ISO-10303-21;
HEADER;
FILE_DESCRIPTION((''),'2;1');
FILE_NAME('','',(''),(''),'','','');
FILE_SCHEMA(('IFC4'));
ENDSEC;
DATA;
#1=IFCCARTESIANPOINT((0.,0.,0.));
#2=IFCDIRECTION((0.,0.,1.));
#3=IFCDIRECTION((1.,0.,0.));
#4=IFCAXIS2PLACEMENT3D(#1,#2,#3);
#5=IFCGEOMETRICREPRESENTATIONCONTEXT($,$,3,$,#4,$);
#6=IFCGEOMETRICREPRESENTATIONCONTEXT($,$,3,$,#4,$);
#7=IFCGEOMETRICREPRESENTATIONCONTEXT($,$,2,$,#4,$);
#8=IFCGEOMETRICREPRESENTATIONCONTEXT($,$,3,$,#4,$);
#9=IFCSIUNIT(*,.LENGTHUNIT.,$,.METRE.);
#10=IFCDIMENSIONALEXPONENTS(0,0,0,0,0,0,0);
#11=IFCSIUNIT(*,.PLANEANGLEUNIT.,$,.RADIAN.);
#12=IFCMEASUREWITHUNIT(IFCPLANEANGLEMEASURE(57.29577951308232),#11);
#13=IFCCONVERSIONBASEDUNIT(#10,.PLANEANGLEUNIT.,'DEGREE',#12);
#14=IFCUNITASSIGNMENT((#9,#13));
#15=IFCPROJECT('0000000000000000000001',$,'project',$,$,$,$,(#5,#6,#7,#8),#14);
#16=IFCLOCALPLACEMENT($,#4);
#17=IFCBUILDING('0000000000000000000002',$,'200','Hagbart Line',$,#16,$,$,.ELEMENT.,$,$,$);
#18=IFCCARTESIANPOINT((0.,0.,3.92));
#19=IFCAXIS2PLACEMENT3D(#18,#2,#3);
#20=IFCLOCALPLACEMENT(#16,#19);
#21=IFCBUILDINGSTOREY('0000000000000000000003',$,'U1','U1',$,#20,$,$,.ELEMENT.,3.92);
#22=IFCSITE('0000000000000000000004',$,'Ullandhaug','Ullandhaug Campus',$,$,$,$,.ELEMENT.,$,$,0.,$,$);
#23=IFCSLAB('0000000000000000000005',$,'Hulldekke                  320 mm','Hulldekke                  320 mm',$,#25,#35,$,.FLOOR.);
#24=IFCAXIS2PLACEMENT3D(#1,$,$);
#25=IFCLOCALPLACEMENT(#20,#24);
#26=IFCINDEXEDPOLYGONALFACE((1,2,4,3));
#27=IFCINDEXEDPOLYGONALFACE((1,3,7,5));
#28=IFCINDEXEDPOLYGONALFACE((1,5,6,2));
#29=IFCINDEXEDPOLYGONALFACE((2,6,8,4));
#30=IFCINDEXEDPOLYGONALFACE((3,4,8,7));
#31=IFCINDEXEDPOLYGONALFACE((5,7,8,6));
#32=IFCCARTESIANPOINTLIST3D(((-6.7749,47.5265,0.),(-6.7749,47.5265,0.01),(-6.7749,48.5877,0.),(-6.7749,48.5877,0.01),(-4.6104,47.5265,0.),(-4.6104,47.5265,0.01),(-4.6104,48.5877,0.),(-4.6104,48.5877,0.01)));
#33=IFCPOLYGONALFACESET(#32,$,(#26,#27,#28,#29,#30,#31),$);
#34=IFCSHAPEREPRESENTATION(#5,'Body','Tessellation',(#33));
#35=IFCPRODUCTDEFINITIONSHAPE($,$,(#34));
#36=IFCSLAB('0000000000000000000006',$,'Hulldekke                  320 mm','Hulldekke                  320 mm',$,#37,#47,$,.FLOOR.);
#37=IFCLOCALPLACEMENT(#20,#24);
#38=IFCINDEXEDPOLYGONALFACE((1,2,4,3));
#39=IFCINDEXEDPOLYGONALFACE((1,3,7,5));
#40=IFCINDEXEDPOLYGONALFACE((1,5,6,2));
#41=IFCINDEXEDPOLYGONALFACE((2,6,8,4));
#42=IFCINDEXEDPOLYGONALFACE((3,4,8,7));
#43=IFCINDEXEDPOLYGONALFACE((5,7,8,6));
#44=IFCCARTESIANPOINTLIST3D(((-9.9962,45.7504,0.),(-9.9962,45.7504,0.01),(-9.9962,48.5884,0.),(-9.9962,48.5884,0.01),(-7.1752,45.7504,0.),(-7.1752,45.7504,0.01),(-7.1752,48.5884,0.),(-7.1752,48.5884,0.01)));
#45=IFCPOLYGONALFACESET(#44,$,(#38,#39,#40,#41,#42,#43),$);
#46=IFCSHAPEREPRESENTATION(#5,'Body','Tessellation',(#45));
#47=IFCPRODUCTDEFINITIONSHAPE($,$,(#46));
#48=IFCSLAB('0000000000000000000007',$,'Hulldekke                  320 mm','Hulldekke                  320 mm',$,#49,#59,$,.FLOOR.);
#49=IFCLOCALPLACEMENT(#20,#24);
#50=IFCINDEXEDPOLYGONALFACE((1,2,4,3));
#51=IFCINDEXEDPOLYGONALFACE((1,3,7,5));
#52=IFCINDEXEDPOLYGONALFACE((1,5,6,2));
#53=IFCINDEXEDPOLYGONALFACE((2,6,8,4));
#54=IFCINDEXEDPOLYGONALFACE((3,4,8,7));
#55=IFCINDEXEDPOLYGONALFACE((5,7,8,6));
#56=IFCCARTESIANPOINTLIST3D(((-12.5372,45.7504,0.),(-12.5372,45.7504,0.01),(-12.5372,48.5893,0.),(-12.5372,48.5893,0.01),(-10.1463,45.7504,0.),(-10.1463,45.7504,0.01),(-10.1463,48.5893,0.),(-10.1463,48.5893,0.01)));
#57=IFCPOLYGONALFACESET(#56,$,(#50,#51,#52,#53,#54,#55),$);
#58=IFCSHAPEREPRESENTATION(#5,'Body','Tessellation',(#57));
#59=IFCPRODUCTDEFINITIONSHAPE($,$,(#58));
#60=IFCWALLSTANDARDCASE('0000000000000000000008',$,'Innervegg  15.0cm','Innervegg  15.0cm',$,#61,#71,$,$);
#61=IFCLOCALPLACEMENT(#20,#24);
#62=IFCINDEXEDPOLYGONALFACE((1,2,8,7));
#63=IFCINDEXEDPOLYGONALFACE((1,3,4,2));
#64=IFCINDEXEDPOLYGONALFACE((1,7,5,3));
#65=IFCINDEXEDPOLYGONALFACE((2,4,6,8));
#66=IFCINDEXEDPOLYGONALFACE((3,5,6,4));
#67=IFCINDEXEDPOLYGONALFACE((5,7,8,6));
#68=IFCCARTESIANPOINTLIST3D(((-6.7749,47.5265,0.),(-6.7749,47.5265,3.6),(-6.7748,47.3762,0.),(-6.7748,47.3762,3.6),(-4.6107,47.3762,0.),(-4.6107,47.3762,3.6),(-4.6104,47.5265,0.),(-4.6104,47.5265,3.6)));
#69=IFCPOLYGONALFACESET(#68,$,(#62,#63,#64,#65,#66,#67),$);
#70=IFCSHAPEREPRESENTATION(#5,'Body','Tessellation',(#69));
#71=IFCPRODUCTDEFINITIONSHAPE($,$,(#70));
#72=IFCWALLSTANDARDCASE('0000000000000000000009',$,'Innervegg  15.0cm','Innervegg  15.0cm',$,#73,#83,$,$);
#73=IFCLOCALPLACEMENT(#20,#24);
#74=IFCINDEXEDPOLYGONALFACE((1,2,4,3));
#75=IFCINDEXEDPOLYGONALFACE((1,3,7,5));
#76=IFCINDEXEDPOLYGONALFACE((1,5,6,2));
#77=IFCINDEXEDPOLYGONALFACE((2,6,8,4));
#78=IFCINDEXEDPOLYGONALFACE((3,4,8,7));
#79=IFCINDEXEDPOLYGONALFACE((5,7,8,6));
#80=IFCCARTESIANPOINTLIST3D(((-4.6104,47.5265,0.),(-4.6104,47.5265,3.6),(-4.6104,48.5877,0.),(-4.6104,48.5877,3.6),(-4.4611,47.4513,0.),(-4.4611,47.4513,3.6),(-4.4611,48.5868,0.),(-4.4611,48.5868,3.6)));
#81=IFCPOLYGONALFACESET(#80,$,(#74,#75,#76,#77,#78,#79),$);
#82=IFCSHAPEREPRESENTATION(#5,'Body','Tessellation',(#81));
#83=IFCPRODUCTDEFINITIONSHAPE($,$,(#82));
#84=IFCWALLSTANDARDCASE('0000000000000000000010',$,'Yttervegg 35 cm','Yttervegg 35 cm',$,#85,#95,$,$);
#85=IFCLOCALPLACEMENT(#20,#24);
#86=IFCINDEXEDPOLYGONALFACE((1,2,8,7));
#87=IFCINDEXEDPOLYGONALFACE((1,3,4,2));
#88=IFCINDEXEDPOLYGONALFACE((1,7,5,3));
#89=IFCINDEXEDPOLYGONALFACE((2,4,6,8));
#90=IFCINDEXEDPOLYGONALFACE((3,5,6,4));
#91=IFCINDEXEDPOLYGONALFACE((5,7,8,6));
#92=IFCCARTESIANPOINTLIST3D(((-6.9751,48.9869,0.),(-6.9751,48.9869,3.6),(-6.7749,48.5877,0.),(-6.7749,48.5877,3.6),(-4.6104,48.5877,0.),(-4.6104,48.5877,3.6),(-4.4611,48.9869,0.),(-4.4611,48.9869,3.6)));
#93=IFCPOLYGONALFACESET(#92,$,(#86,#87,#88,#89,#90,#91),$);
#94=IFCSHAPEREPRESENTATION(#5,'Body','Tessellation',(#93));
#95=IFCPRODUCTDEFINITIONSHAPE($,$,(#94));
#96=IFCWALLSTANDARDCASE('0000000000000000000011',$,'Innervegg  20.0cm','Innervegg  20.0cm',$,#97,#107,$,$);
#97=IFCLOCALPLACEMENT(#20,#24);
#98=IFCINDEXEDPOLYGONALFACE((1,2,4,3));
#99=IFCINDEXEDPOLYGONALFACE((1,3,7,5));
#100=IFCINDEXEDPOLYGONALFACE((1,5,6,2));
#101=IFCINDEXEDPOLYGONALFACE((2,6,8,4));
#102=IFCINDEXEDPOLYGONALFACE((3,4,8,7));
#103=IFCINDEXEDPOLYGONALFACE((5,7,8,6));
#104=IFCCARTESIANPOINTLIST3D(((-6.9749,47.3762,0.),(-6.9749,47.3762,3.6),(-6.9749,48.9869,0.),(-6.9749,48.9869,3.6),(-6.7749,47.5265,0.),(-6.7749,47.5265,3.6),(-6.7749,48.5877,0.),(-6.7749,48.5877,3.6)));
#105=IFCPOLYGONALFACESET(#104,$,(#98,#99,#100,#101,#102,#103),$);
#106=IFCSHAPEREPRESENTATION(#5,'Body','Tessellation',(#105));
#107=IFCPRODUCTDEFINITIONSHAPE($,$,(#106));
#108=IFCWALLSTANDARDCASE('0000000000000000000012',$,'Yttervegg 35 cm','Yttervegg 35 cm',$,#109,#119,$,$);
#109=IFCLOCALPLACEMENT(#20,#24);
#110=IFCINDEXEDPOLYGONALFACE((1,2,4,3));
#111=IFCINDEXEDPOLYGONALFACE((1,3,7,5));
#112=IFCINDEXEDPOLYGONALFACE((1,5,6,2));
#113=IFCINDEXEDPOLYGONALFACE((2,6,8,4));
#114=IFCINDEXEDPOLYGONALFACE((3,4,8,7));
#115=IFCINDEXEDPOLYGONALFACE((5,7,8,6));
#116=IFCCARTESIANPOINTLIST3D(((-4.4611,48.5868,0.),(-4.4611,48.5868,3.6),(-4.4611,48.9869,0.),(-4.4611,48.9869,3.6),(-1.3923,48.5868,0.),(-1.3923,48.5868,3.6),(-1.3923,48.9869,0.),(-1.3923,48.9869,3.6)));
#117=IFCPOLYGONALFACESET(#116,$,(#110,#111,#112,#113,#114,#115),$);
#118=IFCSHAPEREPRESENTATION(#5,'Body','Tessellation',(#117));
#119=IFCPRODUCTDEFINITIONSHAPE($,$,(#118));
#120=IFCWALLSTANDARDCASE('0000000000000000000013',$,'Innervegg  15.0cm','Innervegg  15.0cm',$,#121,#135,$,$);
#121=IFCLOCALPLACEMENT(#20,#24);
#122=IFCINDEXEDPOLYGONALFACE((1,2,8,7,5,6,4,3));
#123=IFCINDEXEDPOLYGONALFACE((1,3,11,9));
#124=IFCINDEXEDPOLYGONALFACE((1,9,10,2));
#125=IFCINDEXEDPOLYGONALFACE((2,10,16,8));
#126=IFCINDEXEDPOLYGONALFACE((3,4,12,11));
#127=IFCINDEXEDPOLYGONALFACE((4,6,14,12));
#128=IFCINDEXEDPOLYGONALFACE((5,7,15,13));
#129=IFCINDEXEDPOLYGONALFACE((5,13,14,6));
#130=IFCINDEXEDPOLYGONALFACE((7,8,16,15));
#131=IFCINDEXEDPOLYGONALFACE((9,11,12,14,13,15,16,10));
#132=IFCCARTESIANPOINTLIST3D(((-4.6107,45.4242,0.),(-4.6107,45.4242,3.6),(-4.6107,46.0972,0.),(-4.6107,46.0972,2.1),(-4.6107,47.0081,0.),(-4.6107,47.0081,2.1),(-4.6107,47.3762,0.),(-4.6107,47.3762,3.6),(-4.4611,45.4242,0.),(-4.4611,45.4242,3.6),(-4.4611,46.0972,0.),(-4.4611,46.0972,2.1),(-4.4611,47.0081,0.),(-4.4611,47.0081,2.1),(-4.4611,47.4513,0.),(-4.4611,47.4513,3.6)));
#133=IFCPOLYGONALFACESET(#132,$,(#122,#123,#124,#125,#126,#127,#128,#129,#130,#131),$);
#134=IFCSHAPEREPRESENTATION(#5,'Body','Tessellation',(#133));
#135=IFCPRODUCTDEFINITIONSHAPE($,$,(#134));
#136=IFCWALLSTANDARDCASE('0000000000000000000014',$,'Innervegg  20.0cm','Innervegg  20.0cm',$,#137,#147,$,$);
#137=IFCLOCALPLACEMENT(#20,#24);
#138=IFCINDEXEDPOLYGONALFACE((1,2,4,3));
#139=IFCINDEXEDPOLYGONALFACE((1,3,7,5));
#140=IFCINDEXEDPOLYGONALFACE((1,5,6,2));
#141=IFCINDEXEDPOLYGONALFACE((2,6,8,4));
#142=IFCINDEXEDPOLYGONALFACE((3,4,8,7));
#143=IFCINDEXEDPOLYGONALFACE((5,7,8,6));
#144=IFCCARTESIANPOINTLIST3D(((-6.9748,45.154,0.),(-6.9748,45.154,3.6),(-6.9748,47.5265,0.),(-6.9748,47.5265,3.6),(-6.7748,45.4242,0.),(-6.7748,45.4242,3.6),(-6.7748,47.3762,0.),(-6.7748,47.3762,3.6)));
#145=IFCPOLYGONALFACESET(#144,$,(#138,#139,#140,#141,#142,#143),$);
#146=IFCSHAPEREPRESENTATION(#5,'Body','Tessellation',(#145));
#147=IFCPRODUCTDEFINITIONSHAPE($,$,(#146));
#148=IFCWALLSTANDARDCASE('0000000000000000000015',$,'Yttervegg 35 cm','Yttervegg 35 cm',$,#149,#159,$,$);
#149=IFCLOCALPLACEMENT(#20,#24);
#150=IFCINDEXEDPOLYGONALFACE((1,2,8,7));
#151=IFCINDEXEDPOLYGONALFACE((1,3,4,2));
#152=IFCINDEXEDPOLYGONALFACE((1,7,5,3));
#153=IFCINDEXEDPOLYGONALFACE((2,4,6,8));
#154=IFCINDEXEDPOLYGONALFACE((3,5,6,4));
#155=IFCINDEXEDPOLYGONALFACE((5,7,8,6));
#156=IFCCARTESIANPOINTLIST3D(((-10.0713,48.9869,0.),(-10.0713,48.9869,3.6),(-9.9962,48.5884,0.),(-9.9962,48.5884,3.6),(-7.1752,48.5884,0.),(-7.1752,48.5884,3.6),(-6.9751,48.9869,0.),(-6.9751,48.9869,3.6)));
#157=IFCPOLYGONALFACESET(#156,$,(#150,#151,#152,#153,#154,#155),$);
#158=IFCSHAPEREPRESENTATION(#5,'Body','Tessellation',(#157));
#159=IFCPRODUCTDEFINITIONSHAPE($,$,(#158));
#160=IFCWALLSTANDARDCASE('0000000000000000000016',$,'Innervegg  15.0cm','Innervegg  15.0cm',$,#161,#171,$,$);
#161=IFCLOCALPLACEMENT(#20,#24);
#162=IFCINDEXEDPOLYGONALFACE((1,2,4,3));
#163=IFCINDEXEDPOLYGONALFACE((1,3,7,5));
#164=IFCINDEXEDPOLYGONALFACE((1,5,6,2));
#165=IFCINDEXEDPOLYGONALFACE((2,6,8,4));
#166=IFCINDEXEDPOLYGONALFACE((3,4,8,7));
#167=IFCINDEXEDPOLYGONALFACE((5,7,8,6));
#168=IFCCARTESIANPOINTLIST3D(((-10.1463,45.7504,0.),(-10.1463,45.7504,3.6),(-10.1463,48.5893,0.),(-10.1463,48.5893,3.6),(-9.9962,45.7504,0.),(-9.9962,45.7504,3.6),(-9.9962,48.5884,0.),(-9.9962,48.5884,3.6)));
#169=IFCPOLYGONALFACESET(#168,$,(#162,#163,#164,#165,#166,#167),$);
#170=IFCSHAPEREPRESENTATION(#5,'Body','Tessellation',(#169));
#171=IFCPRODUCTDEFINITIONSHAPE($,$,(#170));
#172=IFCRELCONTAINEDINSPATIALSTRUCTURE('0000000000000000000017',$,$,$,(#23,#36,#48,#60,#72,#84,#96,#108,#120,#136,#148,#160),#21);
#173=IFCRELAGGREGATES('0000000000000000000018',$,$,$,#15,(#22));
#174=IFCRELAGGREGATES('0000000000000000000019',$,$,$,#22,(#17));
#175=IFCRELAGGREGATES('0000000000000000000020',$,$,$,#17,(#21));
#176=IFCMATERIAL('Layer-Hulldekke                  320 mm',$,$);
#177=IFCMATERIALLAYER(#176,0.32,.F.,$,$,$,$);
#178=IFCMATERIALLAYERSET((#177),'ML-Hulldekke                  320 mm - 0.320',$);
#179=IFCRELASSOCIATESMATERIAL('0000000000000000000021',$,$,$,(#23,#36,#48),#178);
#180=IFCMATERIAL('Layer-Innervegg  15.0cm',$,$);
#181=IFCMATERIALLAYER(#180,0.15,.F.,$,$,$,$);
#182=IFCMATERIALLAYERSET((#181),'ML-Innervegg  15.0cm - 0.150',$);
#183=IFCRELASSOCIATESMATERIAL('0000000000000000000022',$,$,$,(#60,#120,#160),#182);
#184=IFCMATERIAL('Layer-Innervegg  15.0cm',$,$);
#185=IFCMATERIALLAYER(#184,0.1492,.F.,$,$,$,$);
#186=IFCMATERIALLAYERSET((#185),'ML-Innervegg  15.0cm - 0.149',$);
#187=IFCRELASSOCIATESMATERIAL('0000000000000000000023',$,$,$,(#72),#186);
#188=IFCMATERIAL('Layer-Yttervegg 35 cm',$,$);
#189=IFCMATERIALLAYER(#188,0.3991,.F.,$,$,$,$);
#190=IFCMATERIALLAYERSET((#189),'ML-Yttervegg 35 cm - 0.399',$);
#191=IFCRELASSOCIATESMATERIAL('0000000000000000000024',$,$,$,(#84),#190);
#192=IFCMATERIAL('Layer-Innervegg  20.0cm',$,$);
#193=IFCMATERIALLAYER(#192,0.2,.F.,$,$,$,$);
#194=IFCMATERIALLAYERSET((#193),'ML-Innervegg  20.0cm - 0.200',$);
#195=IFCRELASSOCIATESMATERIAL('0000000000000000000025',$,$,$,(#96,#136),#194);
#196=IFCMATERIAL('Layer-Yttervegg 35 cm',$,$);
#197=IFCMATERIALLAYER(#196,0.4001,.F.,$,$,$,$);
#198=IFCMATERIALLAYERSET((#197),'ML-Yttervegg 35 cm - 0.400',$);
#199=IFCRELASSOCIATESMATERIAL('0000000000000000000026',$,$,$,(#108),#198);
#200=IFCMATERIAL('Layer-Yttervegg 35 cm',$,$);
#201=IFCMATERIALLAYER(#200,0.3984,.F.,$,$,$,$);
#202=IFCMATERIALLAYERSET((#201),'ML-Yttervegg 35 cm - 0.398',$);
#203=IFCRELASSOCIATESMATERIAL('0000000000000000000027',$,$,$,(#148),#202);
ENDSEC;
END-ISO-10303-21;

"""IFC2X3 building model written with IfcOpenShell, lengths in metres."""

from ifc_helpers import new_model, entity, si_unit, converted_unit, frame, origin_with_axes, place, context, project, spatial, polyline, outline, extrude, material, layer, layer_set, layer_usage, element, save


model = new_model("IFC2X3")

# Units and contexts
context_of_model_1 = context(None, 3, world=origin_with_axes())
context_of_model_2 = context(None, 3, world=origin_with_axes())
context_of_model_3 = context(None, 2, world=origin_with_axes())
context_of_model_4 = context(None, 3, world=origin_with_axes())
ifc_project = project(units=[si_unit("LENGTHUNIT", "METRE"), converted_unit("PLANEANGLEUNIT", "DEGREE", entity("IfcPlaneAngleMeasure", 57.29577951308232), si_unit("PLANEANGLEUNIT", "RADIAN"), dimensions=[0, 0, 0, 0, 0, 0, 0])], contexts=[context_of_model_1, context_of_model_2, context_of_model_3, context_of_model_4])

# Site, building, storey
site = spatial("IfcSite", under=ifc_project, Name="Ullandhaug", Description="Ullandhaug Campus", CompositionType="ELEMENT", RefElevation=0.0)
building_placement = place(None, origin_with_axes())
building = spatial("IfcBuilding", under=site, at=building_placement, Name="200", Description="Hagbart Line", CompositionType="ELEMENT")
storey_placement = place(building_placement, frame((0.0, 0.0, 3.92), z_axis=(0.0, 0.0, 1.0), x_axis=(1.0, 0.0, 0.0)))
storey = spatial("IfcBuildingStorey", under=building, at=storey_placement, Name="U1", Description="U1", CompositionType="ELEMENT", Elevation=3.92)

# Slabs
ifc_material_1 = material(Name="Layer-Hulldekke                  320 mm")
ifc_layer_1 = layer(ifc_material_1, 0.32, ventilated=False)
ifc_layer_set_1 = layer_set([ifc_layer_1], Name="ML-Hulldekke                  320 mm - 0.320")
ifc_layer_usage_1 = layer_usage(ifc_layer_set_1, "AXIS2", "POSITIVE", 0.0)
slab_1_placement = place(storey_placement, frame((-6.7749, 47.5265, 0.0), z_axis=(0.0, 0.0, 1.0), x_axis=(1.0, 0.0, 0.0)))
element("IfcSlab", 1, at=slab_1_placement, inside=storey, material=ifc_layer_usage_1, Name="Hulldekke                  320 mm", Description="Hulldekke                  320 mm", PredefinedType="FLOOR", context=context_of_model_1, shape_type="SweptSolid", body=[
    extrude(outline(polyline([(0.0, 0.0), (2.1645, 0.0), (2.1645, 1.0613), (0.0, 1.0613), (0.0, 0.0)])), origin_with_axes(), (0.0, 0.0, 1.0), 0.01),
])
slab_2_placement = place(storey_placement, frame((-9.9962, 45.7504, 0.0), z_axis=(0.0, 0.0, 1.0), x_axis=(1.0, 0.0, 0.0)))
element("IfcSlab", 2, at=slab_2_placement, inside=storey, material=ifc_layer_usage_1, Name="Hulldekke                  320 mm", Description="Hulldekke                  320 mm", PredefinedType="FLOOR", context=context_of_model_1, shape_type="SweptSolid", body=[
    extrude(outline(polyline([(0.0, 0.0), (2.821, 0.0), (2.821, 2.838), (0.0, 2.838), (0.0, 0.0)])), origin_with_axes(), (0.0, 0.0, 1.0), 0.01),
])
slab_3_placement = place(storey_placement, frame((-12.5372, 45.7504, 0.0), z_axis=(0.0, 0.0, 1.0), x_axis=(1.0, 0.0, 0.0)))
element("IfcSlab", 3, at=slab_3_placement, inside=storey, material=ifc_layer_usage_1, Name="Hulldekke                  320 mm", Description="Hulldekke                  320 mm", PredefinedType="FLOOR", context=context_of_model_1, shape_type="SweptSolid", body=[
    extrude(outline(polyline([(0.0, 0.0), (2.3909, 0.0), (2.3909, 2.8388), (0.0, 2.8388), (0.0, 0.0)])), origin_with_axes(), (0.0, 0.0, 1.0), 0.01),
])

# Walls
ifc_material_2 = material(Name="Layer-Innervegg  15.0cm")
ifc_layer_2 = layer(ifc_material_2, 0.15, ventilated=False)
ifc_layer_set_2 = layer_set([ifc_layer_2], Name="ML-Innervegg  15.0cm - 0.150")
ifc_layer_usage_2 = layer_usage(ifc_layer_set_2, "AXIS2", "POSITIVE", 0.0)
wall_1_placement = place(storey_placement, frame((-6.7748, 47.3762, 0.0), z_axis=(0.0, 0.0, 1.0), x_axis=(1.0, 0.0, 0.0)))
element("IfcWallStandardCase", 4, at=wall_1_placement, inside=storey, material=ifc_layer_usage_2, Name="Innervegg  15.0cm", Description="Innervegg  15.0cm", context=context_of_model_1, shape_type="SweptSolid", body=[
    extrude(outline(polyline([(0.0, 0.0), (2.1641, 0.0), (2.1644, 0.1503), (-0.0001, 0.1503), (0.0, 0.0)])), origin_with_axes(), (0.0, 0.0, 1.0), 3.6),
])
ifc_material_3 = material(Name="Layer-Innervegg  15.0cm")
ifc_layer_3 = layer(ifc_material_3, 0.1492, ventilated=False)
ifc_layer_set_3 = layer_set([ifc_layer_3], Name="ML-Innervegg  15.0cm - 0.149")
ifc_layer_usage_3 = layer_usage(ifc_layer_set_3, "AXIS2", "POSITIVE", 0.0)
wall_2_placement = place(storey_placement, frame((-4.4611, 47.4513, 0.0), z_axis=(0.0, 0.0, 1.0), x_axis=(0.0, 1.0, 0.0)))
element("IfcWallStandardCase", 5, at=wall_2_placement, inside=storey, material=ifc_layer_usage_3, Name="Innervegg  15.0cm", Description="Innervegg  15.0cm", context=context_of_model_1, shape_type="SweptSolid", body=[
    extrude(outline(polyline([(0.0, 0.0), (1.1355, 0.0), (1.1364, 0.1492), (0.0751, 0.1492), (0.0, 0.0)])), frame((0.0, 0.0, 0.0), z_axis=(0.0, 0.0, 1.0), x_axis=(1.0, 0.0, 0.0)), (0.0, 0.0, 1.0), 3.6),
])
ifc_material_4 = material(Name="Layer-Yttervegg 35 cm")
ifc_layer_4 = layer(ifc_material_4, 0.3991, ventilated=False)
ifc_layer_set_4 = layer_set([ifc_layer_4], Name="ML-Yttervegg 35 cm - 0.399")
ifc_layer_usage_4 = layer_usage(ifc_layer_set_4, "AXIS2", "POSITIVE", 0.0)
wall_3_placement = place(storey_placement, frame((-4.4611, 48.9869, 0.0), z_axis=(0.0, 0.0, 1.0), x_axis=(-1.0, 0.0, 0.0)))
element("IfcWallStandardCase", 6, at=wall_3_placement, inside=storey, material=ifc_layer_usage_4, Name="Yttervegg 35 cm", Description="Yttervegg 35 cm", context=context_of_model_1, shape_type="SweptSolid", body=[
    extrude(outline(polyline([(0.0, 0.0), (2.5139, 0.0), (2.3138, 0.3991), (0.1492, 0.3991), (0.0, 0.0)])), frame((0.0, 0.0, 0.0), z_axis=(0.0, 0.0, 1.0), x_axis=(1.0, 0.0, 0.0)), (0.0, 0.0, 1.0), 3.6),
])
ifc_material_5 = material(Name="Layer-Innervegg  20.0cm")
ifc_layer_5 = layer(ifc_material_5, 0.2, ventilated=False)
ifc_layer_set_5 = layer_set([ifc_layer_5], Name="ML-Innervegg  20.0cm - 0.200")
ifc_layer_usage_5 = layer_usage(ifc_layer_set_5, "AXIS2", "POSITIVE", 0.0)
wall_4_placement = place(storey_placement, frame((-6.9749, 48.9869, 0.0), z_axis=(0.0, 0.0, 1.0), x_axis=(0.0, -1.0, 0.0)))
element("IfcWallStandardCase", 7, at=wall_4_placement, inside=storey, material=ifc_layer_usage_5, Name="Innervegg  20.0cm", Description="Innervegg  20.0cm", context=context_of_model_1, shape_type="SweptSolid", body=[
    extrude(outline(polyline([(0.0, 0.0), (1.6107, 0.0), (1.4604, 0.2), (0.3991, 0.2), (0.0, 0.0)])), frame((0.0, 0.0, 0.0), z_axis=(0.0, 0.0, 1.0), x_axis=(1.0, 0.0, 0.0)), (0.0, 0.0, 1.0), 3.6),
])
ifc_material_6 = material(Name="Layer-Yttervegg 35 cm")
ifc_layer_6 = layer(ifc_material_6, 0.4001, ventilated=False)
ifc_layer_set_6 = layer_set([ifc_layer_6], Name="ML-Yttervegg 35 cm - 0.400")
ifc_layer_usage_6 = layer_usage(ifc_layer_set_6, "AXIS2", "POSITIVE", 0.0)
wall_5_placement = place(storey_placement, frame((-1.3923, 48.9869, 0.0), z_axis=(0.0, 0.0, 1.0), x_axis=(-1.0, 0.000001, 0.0)))
element("IfcWallStandardCase", 8, at=wall_5_placement, inside=storey, material=ifc_layer_usage_6, Name="Yttervegg 35 cm", Description="Yttervegg 35 cm", context=context_of_model_1, shape_type="SweptSolid", body=[
    extrude(outline(polyline([(0.0, 0.0), (3.0688, 0.0), (3.0688, 0.4001), (0.0, 0.4001), (0.0, 0.0)])), frame((0.0, 0.0, 0.0), z_axis=(0.0, 0.0, 1.0), x_axis=(1.0, 0.0, 0.0)), (0.0, 0.0, 1.0), 3.6),
])

# Wall, opening
wall_6_placement = place(storey_placement, frame((-4.6107, 47.3762, 0.0), z_axis=(0.0, 0.0, 1.0), x_axis=(0.0, -1.0, 0.0)))
wall_6 = element("IfcWallStandardCase", 9, at=wall_6_placement, inside=storey, material=ifc_layer_usage_2, Name="Innervegg  15.0cm", Description="Innervegg  15.0cm", context=context_of_model_1, shape_type="SweptSolid", body=[
    extrude(outline(polyline([(0.0, 0.0), (1.9519, 0.0), (1.9519, 0.1496), (-0.0751, 0.1496), (0.0, 0.0)])), frame((0.0, 0.0, 0.0), z_axis=(0.0, 0.0, 1.0), x_axis=(1.0, 0.0, 0.0)), (0.0, 0.0, 1.0), 3.6),
])
opening_1_placement = place(wall_6_placement, frame((0.3681, 0.1496, 0.0), z_axis=(0.0, 0.0, 1.0), x_axis=(1.0, 0.0, 0.0)))
element("IfcOpeningElement", 10, at=opening_1_placement, cuts=wall_6, context=context_of_model_1, shape_type="SweptSolid", body=[
    extrude(outline(polyline([(0.0, 0.0), (2.1, 0.0), (2.1, 0.9109), (0.0, 0.9109), (0.0, 0.0)])), frame((0.0, 0.0, 0.0), z_axis=(0.0, 1.0, 0.0), x_axis=(0.0, 0.0, 1.0)), (0.0, 0.0, -1.0), 0.1496),
])

# Walls
wall_7_placement = place(storey_placement, frame((-6.9748, 47.5265, 0.0), z_axis=(0.0, 0.0, 1.0), x_axis=(0.0, -1.0, 0.0)))
element("IfcWallStandardCase", 11, at=wall_7_placement, inside=storey, material=ifc_layer_usage_5, Name="Innervegg  20.0cm", Description="Innervegg  20.0cm", context=context_of_model_1, shape_type="SweptSolid", body=[
    extrude(outline(polyline([(0.0, 0.0), (2.3725, 0.0), (2.1022, 0.2), (0.1503, 0.2), (0.0, 0.0)])), frame((0.0, 0.0, 0.0), z_axis=(0.0, 0.0, 1.0), x_axis=(1.0, 0.0, 0.0)), (0.0, 0.0, 1.0), 3.6),
])
ifc_material_7 = material(Name="Layer-Yttervegg 35 cm")
ifc_layer_7 = layer(ifc_material_7, 0.3984, ventilated=False)
ifc_layer_set_7 = layer_set([ifc_layer_7], Name="ML-Yttervegg 35 cm - 0.398")
ifc_layer_usage_7 = layer_usage(ifc_layer_set_7, "AXIS2", "POSITIVE", 0.0)
wall_8_placement = place(storey_placement, frame((-6.9751, 48.9869, 0.0), z_axis=(0.0, 0.0, 1.0), x_axis=(-1.0, 0.0, 0.0)))
element("IfcWallStandardCase", 12, at=wall_8_placement, inside=storey, material=ifc_layer_usage_7, Name="Yttervegg 35 cm", Description="Yttervegg 35 cm", context=context_of_model_1, shape_type="SweptSolid", body=[
    extrude(outline(polyline([(0.0, 0.0), (3.0962, 0.0), (3.0211, 0.3984), (0.2002, 0.3984), (0.0, 0.0)])), frame((0.0, 0.0, 0.0), z_axis=(0.0, 0.0, 1.0), x_axis=(1.0, 0.0, 0.0)), (0.0, 0.0, 1.0), 3.6),
])
wall_9_placement = place(storey_placement, frame((-10.1463, 48.5893, 0.0), z_axis=(0.0, 0.0, 1.0), x_axis=(0.0, -1.0, 0.0)))
element("IfcWallStandardCase", 13, at=wall_9_placement, inside=storey, material=ifc_layer_usage_2, Name="Innervegg  15.0cm", Description="Innervegg  15.0cm", context=context_of_model_1, shape_type="SweptSolid", body=[
    extrude(outline(polyline([(0.0, 0.0), (2.8388, 0.0), (2.8388, 0.1501), (0.0008, 0.1501), (0.0, 0.0)])), frame((0.0, 0.0, 0.0), z_axis=(0.0, 0.0, 1.0), x_axis=(1.0, 0.0, 0.0)), (0.0, 0.0, 1.0), 3.6),
])

save(model, "model.ifc")
